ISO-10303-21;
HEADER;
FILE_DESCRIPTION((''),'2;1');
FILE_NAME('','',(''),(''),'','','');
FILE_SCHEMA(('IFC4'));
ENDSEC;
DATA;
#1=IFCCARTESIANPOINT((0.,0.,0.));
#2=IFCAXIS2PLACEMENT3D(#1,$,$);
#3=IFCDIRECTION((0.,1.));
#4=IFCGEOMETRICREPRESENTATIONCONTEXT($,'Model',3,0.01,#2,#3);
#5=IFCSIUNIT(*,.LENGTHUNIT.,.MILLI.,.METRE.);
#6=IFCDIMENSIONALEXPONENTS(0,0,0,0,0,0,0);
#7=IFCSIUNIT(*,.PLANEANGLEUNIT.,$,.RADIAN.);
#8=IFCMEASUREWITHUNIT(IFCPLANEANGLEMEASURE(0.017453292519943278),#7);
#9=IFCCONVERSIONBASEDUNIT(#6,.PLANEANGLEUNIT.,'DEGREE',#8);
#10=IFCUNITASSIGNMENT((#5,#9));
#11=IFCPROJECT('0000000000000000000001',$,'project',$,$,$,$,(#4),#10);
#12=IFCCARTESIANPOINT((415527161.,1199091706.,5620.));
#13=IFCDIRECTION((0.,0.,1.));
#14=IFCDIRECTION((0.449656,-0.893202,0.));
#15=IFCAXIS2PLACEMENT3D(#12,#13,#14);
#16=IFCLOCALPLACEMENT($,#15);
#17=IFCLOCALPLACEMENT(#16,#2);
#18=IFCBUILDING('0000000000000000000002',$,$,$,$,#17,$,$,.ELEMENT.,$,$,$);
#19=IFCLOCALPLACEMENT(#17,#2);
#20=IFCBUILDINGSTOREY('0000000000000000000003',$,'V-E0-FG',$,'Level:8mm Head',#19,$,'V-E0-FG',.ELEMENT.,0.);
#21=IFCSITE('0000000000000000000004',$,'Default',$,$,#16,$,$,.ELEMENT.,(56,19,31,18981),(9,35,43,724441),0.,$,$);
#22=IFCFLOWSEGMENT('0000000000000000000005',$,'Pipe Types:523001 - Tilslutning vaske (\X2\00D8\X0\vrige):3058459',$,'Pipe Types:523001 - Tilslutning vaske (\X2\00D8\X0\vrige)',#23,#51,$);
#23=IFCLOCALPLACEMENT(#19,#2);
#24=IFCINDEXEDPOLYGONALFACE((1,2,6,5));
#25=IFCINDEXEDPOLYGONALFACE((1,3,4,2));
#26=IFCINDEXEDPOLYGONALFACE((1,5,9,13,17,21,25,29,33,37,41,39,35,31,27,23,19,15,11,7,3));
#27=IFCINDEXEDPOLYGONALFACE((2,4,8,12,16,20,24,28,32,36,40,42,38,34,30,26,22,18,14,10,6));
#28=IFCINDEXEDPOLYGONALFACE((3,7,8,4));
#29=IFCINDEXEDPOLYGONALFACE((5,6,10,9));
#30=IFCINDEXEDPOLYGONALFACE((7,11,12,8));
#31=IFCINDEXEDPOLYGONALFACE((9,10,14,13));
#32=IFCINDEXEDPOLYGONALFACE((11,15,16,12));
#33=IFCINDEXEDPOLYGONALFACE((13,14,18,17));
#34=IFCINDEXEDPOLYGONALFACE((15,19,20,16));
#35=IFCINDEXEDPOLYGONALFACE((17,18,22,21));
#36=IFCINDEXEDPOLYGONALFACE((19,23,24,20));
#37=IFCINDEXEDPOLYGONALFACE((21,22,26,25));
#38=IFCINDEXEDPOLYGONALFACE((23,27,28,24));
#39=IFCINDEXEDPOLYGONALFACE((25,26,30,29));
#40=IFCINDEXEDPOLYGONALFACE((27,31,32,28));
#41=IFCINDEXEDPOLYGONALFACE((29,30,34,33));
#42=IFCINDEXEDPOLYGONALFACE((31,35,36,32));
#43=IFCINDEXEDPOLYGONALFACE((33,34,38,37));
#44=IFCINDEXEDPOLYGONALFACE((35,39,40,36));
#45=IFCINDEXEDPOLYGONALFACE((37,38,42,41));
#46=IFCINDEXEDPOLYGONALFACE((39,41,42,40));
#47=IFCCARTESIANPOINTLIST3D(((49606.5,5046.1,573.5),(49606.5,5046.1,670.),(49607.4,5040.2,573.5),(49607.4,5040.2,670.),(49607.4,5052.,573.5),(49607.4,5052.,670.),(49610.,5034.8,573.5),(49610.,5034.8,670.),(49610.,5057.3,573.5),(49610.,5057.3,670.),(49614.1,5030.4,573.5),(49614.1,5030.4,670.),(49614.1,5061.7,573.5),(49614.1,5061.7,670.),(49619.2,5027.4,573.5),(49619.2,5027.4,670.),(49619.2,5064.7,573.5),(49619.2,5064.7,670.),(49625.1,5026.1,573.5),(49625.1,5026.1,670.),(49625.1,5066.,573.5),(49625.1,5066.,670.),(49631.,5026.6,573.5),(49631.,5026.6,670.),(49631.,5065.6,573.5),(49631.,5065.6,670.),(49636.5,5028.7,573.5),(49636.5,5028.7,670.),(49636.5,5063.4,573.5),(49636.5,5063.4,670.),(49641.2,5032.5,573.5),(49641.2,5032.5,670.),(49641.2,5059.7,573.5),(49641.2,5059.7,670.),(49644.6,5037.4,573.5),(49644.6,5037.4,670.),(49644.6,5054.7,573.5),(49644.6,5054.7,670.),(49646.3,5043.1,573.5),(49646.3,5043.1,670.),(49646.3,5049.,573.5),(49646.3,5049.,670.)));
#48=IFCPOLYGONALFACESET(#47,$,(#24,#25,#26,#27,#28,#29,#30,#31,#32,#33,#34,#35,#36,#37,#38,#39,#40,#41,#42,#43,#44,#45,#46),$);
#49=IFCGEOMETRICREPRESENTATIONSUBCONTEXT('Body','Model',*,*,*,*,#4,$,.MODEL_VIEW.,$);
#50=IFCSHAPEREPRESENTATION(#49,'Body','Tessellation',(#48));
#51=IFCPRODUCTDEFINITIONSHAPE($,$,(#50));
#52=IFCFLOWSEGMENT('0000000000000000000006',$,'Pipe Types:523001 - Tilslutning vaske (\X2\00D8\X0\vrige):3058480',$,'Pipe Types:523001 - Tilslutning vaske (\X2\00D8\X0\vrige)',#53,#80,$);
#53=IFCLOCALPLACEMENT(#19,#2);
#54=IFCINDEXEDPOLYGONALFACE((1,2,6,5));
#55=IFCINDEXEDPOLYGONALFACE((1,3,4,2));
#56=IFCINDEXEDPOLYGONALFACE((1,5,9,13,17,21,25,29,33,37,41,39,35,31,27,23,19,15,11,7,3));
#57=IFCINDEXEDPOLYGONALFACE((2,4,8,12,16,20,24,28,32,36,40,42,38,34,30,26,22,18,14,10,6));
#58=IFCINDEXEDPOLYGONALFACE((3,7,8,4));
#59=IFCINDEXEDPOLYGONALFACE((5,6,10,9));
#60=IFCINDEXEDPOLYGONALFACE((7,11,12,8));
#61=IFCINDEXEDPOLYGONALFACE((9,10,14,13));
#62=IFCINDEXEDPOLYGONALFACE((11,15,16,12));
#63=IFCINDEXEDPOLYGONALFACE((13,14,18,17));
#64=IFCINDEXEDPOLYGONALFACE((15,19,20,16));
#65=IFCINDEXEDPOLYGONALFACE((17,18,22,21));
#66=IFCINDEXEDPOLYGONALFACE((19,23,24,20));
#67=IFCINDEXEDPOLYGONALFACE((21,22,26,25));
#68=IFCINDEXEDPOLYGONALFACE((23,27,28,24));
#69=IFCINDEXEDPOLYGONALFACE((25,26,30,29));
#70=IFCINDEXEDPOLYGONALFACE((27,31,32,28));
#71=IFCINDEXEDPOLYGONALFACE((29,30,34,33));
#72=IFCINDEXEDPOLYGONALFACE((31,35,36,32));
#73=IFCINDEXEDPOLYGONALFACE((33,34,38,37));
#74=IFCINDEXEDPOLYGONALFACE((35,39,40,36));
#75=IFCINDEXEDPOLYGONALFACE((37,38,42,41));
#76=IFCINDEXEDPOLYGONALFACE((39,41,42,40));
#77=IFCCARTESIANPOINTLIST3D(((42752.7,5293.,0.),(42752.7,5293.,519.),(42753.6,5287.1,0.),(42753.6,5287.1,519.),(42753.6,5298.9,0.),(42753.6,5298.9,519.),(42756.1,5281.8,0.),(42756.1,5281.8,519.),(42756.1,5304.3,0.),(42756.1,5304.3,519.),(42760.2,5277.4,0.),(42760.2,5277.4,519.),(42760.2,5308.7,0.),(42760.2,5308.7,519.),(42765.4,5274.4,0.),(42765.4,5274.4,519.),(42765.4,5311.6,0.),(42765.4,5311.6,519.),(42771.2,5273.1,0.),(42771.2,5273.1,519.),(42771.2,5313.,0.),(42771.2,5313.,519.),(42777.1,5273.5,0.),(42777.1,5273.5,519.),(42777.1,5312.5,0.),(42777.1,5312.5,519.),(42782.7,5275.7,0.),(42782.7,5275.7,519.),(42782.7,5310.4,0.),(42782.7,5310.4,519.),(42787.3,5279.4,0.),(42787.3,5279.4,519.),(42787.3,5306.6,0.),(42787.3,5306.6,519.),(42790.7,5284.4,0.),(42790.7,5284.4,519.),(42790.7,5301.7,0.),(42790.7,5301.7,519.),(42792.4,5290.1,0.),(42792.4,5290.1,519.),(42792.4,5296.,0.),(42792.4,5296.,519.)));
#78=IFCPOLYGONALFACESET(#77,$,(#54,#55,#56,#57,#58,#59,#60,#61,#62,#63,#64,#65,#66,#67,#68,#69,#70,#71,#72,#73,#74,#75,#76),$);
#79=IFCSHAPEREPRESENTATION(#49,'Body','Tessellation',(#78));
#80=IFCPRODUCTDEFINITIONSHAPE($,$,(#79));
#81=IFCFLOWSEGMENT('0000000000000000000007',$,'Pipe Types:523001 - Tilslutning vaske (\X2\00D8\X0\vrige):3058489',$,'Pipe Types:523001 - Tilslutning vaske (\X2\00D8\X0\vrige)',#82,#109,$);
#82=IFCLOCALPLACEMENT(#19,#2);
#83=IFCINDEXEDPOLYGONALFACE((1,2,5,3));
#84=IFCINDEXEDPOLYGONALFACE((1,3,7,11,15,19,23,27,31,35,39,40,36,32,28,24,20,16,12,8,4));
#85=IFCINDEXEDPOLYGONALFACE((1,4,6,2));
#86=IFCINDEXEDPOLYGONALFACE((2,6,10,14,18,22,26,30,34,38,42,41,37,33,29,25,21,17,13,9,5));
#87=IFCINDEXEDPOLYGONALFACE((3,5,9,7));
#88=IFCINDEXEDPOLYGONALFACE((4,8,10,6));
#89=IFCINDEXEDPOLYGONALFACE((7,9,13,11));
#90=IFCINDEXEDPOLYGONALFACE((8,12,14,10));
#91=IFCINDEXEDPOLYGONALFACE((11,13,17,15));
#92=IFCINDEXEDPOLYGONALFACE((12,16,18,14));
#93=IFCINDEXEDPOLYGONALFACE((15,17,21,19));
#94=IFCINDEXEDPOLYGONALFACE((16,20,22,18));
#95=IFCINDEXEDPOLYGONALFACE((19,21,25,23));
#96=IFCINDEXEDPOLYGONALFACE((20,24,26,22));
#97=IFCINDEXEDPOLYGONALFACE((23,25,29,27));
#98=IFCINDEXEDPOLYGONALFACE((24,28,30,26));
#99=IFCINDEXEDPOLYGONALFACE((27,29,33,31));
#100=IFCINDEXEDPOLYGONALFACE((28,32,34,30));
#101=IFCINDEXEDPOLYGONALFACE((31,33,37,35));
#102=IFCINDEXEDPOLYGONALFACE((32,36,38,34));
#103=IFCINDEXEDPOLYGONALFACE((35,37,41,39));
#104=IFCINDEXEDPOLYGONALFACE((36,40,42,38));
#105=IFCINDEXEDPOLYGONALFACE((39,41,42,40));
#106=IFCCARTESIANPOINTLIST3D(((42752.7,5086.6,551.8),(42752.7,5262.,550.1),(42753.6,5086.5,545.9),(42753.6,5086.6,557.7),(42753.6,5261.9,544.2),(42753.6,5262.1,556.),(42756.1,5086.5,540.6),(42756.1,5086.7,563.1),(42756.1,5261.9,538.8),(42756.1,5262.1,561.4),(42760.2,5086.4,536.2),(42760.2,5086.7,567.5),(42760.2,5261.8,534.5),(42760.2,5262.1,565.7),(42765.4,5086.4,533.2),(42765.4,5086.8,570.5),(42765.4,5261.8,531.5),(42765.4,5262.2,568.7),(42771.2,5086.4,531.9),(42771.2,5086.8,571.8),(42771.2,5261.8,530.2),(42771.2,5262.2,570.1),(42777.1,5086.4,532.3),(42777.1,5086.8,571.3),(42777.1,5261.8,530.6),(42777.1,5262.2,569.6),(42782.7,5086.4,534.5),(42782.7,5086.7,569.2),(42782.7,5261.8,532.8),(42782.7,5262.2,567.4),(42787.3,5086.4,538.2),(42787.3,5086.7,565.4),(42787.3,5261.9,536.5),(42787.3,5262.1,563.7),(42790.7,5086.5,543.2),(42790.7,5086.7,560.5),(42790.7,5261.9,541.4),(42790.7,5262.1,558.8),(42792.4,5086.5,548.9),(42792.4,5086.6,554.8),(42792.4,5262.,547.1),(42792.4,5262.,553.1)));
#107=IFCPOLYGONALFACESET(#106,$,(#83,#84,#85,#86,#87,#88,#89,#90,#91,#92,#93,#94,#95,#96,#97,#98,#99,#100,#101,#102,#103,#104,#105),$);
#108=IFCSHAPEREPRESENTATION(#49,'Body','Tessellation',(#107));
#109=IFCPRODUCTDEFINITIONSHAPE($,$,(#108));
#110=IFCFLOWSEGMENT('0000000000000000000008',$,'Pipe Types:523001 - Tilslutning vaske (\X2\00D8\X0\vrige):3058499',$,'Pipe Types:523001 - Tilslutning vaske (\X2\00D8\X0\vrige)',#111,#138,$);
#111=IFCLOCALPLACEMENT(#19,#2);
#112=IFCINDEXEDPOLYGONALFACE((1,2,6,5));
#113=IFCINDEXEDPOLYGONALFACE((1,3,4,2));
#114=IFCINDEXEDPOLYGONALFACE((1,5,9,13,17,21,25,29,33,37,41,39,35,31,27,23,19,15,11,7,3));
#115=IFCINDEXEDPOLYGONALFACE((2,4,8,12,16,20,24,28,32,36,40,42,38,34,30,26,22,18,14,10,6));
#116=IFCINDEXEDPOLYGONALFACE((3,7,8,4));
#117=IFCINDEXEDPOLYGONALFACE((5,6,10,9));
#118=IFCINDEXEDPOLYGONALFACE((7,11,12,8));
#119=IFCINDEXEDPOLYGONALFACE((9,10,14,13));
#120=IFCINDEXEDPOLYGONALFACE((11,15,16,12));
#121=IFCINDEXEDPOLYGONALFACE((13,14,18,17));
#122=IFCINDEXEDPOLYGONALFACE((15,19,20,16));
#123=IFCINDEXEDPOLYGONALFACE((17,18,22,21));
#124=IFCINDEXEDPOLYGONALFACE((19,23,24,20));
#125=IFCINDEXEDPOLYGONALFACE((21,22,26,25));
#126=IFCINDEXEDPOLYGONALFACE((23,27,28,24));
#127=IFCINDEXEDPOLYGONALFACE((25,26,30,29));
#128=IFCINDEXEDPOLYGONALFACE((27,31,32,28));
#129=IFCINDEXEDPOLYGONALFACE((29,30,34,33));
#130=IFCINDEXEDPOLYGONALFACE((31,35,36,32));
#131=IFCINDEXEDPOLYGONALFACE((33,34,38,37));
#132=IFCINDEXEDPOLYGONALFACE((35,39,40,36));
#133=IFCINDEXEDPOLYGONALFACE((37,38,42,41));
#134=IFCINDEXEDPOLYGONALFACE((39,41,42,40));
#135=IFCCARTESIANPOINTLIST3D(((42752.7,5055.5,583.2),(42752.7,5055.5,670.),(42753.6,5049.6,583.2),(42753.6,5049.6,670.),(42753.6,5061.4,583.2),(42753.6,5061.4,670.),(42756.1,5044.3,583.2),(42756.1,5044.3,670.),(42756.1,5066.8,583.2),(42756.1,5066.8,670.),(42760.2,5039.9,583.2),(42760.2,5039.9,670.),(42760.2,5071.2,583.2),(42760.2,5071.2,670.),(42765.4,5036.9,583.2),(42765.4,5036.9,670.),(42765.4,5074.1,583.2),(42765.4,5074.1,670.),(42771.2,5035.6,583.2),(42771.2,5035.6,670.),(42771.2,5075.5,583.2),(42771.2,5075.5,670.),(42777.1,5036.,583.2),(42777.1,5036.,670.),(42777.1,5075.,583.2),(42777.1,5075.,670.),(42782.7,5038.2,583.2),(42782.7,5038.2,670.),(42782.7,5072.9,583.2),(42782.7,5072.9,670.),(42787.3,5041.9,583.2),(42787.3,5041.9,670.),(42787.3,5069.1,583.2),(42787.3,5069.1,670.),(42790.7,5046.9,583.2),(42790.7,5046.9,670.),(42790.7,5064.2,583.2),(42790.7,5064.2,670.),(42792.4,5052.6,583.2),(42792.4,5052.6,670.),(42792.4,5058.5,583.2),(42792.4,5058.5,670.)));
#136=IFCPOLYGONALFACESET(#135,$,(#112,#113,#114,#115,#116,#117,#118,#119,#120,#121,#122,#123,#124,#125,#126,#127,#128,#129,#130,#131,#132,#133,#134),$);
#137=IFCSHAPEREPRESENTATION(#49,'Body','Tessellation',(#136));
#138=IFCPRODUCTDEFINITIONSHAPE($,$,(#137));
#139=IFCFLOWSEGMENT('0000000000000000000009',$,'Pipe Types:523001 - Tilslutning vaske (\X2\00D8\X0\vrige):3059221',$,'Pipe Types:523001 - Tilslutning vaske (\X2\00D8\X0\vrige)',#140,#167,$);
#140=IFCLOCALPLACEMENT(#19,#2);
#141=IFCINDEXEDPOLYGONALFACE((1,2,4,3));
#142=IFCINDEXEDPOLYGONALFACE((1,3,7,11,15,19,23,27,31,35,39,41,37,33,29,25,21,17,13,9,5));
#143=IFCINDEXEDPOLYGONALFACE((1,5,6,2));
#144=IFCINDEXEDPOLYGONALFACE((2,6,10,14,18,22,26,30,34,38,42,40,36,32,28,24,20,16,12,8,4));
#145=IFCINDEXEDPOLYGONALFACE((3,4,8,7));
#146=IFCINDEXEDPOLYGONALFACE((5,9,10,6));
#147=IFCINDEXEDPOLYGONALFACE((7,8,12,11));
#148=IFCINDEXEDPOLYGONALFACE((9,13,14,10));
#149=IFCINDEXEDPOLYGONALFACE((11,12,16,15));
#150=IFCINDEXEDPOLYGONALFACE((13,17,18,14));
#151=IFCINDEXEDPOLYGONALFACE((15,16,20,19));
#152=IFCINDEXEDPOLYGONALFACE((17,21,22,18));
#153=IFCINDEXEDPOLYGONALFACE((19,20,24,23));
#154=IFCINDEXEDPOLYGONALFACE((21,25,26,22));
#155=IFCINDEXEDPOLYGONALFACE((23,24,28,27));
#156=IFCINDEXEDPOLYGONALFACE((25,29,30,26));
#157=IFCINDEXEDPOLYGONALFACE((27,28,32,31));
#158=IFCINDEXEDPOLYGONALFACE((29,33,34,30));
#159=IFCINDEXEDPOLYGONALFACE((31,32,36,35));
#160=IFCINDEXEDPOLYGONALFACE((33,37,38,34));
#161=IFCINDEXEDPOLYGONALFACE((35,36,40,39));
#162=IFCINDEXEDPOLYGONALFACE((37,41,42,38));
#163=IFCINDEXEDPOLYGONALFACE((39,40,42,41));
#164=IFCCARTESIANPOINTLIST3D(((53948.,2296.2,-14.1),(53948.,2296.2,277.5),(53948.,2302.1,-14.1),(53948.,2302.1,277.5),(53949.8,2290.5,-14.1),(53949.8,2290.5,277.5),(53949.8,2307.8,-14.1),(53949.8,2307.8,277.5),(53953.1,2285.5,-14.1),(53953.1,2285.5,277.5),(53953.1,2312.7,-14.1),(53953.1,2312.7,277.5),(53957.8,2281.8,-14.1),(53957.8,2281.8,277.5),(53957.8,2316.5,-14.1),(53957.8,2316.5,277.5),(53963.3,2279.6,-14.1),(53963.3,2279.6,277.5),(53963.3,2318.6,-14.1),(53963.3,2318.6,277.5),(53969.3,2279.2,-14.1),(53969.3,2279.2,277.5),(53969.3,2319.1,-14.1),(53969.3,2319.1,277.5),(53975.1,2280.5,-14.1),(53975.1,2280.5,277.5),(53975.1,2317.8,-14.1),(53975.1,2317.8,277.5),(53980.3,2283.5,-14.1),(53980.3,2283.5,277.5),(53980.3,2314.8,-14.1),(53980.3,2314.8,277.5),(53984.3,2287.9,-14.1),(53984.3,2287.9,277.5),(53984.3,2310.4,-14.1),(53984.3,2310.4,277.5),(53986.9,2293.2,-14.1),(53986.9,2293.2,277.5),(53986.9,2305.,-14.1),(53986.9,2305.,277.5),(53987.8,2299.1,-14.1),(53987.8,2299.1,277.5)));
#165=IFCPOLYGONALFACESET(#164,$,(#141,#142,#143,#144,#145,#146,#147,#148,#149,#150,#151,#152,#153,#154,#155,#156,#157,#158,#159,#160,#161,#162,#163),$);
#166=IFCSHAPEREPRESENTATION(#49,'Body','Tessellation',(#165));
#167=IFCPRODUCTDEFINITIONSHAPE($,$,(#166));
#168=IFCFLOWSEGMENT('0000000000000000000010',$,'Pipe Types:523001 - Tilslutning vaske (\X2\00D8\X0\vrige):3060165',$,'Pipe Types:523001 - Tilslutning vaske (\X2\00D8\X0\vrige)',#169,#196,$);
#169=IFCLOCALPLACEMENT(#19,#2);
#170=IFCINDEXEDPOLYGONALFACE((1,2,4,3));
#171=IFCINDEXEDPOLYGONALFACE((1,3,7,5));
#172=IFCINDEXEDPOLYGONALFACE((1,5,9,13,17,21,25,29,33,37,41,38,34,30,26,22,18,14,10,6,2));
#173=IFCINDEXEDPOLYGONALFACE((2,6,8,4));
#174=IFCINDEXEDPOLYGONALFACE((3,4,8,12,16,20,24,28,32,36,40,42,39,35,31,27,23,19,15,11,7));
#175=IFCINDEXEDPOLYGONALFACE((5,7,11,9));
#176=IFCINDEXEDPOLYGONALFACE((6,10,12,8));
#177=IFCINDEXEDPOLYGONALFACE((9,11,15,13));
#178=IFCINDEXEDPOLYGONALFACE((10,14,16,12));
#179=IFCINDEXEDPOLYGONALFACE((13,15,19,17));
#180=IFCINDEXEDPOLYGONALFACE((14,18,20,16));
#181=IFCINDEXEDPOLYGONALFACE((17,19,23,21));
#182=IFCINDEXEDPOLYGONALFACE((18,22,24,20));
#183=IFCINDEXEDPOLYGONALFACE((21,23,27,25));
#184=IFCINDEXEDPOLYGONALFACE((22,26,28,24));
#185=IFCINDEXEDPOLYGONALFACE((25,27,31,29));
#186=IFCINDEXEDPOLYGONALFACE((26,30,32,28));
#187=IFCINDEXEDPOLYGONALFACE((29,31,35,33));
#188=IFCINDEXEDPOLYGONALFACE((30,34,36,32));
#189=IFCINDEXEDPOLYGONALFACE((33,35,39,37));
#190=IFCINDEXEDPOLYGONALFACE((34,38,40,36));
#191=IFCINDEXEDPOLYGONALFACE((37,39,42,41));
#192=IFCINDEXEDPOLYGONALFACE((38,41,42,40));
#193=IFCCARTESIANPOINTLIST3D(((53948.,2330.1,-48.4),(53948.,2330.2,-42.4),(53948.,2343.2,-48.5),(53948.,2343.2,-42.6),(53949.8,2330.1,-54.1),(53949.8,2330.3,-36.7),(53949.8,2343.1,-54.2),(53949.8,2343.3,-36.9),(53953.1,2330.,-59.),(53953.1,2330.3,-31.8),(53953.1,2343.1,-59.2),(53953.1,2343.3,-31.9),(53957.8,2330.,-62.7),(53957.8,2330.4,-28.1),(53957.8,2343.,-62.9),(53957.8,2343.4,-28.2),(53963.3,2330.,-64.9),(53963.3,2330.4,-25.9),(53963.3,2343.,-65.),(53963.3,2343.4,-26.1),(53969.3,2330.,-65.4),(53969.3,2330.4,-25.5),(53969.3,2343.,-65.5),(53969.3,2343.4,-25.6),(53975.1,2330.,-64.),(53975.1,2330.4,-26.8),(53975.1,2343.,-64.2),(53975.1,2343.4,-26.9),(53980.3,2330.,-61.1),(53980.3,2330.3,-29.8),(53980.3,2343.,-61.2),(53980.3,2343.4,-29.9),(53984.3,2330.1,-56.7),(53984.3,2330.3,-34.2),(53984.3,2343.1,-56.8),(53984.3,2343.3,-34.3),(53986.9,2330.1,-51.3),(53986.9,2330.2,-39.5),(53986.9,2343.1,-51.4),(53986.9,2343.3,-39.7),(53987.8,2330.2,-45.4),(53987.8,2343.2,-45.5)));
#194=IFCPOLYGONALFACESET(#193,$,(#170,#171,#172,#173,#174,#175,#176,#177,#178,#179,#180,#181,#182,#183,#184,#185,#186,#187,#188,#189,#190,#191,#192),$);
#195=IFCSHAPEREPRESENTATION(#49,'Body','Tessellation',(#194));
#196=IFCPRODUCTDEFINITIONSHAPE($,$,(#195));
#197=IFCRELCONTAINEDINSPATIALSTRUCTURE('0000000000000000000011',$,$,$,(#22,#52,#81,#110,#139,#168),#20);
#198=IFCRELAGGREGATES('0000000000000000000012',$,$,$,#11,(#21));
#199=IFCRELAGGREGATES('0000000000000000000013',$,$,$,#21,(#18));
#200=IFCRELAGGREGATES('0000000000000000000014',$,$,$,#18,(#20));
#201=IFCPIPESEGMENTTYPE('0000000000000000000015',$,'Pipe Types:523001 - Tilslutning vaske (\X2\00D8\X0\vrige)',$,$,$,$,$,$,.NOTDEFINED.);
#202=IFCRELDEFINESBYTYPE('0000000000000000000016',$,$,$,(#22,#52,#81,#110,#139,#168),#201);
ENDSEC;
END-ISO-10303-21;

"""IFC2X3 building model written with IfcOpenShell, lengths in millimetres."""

from ifc_helpers import new_model, entity, si_unit, converted_unit, direction, frame, frame_2d, origin, origin_2d_with_axis, place, context, subcontext, project, spatial, circle, extrude, type_object, element, save


model = new_model("IFC2X3")

# Units and contexts
model_context = context("Model", 3, precision=0.01, world=origin(), true_north=direction((0.0, 1.0)))
body_context = subcontext(model_context, "Body", "Model", "MODEL_VIEW")
ifc_project = project(units=[si_unit("LENGTHUNIT", "METRE", prefix="MILLI"), converted_unit("PLANEANGLEUNIT", "DEGREE", entity("IfcPlaneAngleMeasure", 0.017453292519943278), si_unit("PLANEANGLEUNIT", "RADIAN"), dimensions=[0, 0, 0, 0, 0, 0, 0])], contexts=[model_context])

# Site, building, storey
site_placement = place(None, frame((415527161.0, 1199091706.0, 5620.0), z_axis=(0.0, 0.0, 1.0), x_axis=(0.449656, -0.893202, 0.0)))
site = spatial("IfcSite", under=ifc_project, at=site_placement, Name="Default", CompositionType="ELEMENT", RefLatitude=(56, 19, 31, 18981), RefLongitude=(9, 35, 43, 724441), RefElevation=0.0)
building_placement = place(site_placement, origin())
building = spatial("IfcBuilding", under=site, at=building_placement, CompositionType="ELEMENT")
storey_placement = place(building_placement, origin())
storey = spatial("IfcBuildingStorey", under=building, at=storey_placement, Name="V-E0-FG", ObjectType="Level:8mm Head", LongName="V-E0-FG", CompositionType="ELEMENT", Elevation=0.0)

# Flow segments
pipe_segment_type_1 = type_object("IfcPipeSegmentType", Name="Pipe Types:523001 - Tilslutning vaske (Øvrige)", PredefinedType="NOTDEFINED")
flow_segment_1_placement = place(storey_placement, origin())
element("IfcFlowSegment", 1, at=flow_segment_1_placement, inside=storey, type_object=pipe_segment_type_1, Name="Pipe Types:523001 - Tilslutning vaske (Øvrige):3058459", ObjectType="Pipe Types:523001 - Tilslutning vaske (Øvrige)", context=body_context, shape_type="SweptSolid", body=[
    extrude(circle(Radius=20.0, at=origin_2d_with_axis()), frame((49626.5, 5046.1, 573.5), z_axis=(0.0, 0.0, 1.0), x_axis=(-1.0, 0.0, 0.0)), (0.0, 0.0, 1.0), 96.5),
])
flow_segment_2_placement = place(storey_placement, origin())
element("IfcFlowSegment", 2, at=flow_segment_2_placement, inside=storey, type_object=pipe_segment_type_1, Name="Pipe Types:523001 - Tilslutning vaske (Øvrige):3058480", ObjectType="Pipe Types:523001 - Tilslutning vaske (Øvrige)", context=body_context, shape_type="SweptSolid", body=[
    extrude(circle(Radius=20.0, at=origin_2d_with_axis()), frame((42772.7, 5293.0, 0.0), z_axis=(0.0, 0.0, 1.0), x_axis=(-1.0, 0.0, 0.0)), (0.0, 0.0, 1.0), 519.0),
])
flow_segment_3_placement = place(storey_placement, origin())
element("IfcFlowSegment", 3, at=flow_segment_3_placement, inside=storey, type_object=pipe_segment_type_1, Name="Pipe Types:523001 - Tilslutning vaske (Øvrige):3058489", ObjectType="Pipe Types:523001 - Tilslutning vaske (Øvrige)", context=body_context, shape_type="SweptSolid", body=[
    extrude(circle(Radius=20.0, at=origin_2d_with_axis()), frame((42772.7, 5262.0, 550.1), z_axis=(0.0, -0.999951, 0.009857), x_axis=(-1.0, 0.0, 0.0)), (0.0, 0.0, 1.0), 175.4),
])
flow_segment_4_placement = place(storey_placement, origin())
element("IfcFlowSegment", 4, at=flow_segment_4_placement, inside=storey, type_object=pipe_segment_type_1, Name="Pipe Types:523001 - Tilslutning vaske (Øvrige):3058499", ObjectType="Pipe Types:523001 - Tilslutning vaske (Øvrige)", context=body_context, shape_type="SweptSolid", body=[
    extrude(circle(Radius=20.0, at=origin_2d_with_axis()), frame((42772.7, 5055.5, 583.2), z_axis=(0.0, 0.0, 1.0), x_axis=(-1.0, 0.0, 0.0)), (0.0, 0.0, 1.0), 86.8),
])
flow_segment_5_placement = place(storey_placement, origin())
element("IfcFlowSegment", 5, at=flow_segment_5_placement, inside=storey, type_object=pipe_segment_type_1, Name="Pipe Types:523001 - Tilslutning vaske (Øvrige):3059221", ObjectType="Pipe Types:523001 - Tilslutning vaske (Øvrige)", context=body_context, shape_type="SweptSolid", body=[
    extrude(circle(Radius=20.0, at=origin_2d_with_axis()), frame((53967.8, 2299.1, -14.1)), (0.0, 0.0, 1.0), 291.6),
])
flow_segment_6_placement = place(storey_placement, origin())
element("IfcFlowSegment", 6, at=flow_segment_6_placement, inside=storey, type_object=pipe_segment_type_1, Name="Pipe Types:523001 - Tilslutning vaske (Øvrige):3060165", ObjectType="Pipe Types:523001 - Tilslutning vaske (Øvrige)", context=body_context, shape_type="SweptSolid", body=[
    extrude(circle(Radius=20.0, at=frame_2d((0.0, 0.0), x_axis=(1.0, 0.0))), frame((53967.8, 2343.2, -45.5), z_axis=(0.0, -0.99995, 0.01), x_axis=(1.0, 0.0, 0.0)), (0.0, 0.0, 1.0), 13.0),
])

save(model, "model.ifc")
